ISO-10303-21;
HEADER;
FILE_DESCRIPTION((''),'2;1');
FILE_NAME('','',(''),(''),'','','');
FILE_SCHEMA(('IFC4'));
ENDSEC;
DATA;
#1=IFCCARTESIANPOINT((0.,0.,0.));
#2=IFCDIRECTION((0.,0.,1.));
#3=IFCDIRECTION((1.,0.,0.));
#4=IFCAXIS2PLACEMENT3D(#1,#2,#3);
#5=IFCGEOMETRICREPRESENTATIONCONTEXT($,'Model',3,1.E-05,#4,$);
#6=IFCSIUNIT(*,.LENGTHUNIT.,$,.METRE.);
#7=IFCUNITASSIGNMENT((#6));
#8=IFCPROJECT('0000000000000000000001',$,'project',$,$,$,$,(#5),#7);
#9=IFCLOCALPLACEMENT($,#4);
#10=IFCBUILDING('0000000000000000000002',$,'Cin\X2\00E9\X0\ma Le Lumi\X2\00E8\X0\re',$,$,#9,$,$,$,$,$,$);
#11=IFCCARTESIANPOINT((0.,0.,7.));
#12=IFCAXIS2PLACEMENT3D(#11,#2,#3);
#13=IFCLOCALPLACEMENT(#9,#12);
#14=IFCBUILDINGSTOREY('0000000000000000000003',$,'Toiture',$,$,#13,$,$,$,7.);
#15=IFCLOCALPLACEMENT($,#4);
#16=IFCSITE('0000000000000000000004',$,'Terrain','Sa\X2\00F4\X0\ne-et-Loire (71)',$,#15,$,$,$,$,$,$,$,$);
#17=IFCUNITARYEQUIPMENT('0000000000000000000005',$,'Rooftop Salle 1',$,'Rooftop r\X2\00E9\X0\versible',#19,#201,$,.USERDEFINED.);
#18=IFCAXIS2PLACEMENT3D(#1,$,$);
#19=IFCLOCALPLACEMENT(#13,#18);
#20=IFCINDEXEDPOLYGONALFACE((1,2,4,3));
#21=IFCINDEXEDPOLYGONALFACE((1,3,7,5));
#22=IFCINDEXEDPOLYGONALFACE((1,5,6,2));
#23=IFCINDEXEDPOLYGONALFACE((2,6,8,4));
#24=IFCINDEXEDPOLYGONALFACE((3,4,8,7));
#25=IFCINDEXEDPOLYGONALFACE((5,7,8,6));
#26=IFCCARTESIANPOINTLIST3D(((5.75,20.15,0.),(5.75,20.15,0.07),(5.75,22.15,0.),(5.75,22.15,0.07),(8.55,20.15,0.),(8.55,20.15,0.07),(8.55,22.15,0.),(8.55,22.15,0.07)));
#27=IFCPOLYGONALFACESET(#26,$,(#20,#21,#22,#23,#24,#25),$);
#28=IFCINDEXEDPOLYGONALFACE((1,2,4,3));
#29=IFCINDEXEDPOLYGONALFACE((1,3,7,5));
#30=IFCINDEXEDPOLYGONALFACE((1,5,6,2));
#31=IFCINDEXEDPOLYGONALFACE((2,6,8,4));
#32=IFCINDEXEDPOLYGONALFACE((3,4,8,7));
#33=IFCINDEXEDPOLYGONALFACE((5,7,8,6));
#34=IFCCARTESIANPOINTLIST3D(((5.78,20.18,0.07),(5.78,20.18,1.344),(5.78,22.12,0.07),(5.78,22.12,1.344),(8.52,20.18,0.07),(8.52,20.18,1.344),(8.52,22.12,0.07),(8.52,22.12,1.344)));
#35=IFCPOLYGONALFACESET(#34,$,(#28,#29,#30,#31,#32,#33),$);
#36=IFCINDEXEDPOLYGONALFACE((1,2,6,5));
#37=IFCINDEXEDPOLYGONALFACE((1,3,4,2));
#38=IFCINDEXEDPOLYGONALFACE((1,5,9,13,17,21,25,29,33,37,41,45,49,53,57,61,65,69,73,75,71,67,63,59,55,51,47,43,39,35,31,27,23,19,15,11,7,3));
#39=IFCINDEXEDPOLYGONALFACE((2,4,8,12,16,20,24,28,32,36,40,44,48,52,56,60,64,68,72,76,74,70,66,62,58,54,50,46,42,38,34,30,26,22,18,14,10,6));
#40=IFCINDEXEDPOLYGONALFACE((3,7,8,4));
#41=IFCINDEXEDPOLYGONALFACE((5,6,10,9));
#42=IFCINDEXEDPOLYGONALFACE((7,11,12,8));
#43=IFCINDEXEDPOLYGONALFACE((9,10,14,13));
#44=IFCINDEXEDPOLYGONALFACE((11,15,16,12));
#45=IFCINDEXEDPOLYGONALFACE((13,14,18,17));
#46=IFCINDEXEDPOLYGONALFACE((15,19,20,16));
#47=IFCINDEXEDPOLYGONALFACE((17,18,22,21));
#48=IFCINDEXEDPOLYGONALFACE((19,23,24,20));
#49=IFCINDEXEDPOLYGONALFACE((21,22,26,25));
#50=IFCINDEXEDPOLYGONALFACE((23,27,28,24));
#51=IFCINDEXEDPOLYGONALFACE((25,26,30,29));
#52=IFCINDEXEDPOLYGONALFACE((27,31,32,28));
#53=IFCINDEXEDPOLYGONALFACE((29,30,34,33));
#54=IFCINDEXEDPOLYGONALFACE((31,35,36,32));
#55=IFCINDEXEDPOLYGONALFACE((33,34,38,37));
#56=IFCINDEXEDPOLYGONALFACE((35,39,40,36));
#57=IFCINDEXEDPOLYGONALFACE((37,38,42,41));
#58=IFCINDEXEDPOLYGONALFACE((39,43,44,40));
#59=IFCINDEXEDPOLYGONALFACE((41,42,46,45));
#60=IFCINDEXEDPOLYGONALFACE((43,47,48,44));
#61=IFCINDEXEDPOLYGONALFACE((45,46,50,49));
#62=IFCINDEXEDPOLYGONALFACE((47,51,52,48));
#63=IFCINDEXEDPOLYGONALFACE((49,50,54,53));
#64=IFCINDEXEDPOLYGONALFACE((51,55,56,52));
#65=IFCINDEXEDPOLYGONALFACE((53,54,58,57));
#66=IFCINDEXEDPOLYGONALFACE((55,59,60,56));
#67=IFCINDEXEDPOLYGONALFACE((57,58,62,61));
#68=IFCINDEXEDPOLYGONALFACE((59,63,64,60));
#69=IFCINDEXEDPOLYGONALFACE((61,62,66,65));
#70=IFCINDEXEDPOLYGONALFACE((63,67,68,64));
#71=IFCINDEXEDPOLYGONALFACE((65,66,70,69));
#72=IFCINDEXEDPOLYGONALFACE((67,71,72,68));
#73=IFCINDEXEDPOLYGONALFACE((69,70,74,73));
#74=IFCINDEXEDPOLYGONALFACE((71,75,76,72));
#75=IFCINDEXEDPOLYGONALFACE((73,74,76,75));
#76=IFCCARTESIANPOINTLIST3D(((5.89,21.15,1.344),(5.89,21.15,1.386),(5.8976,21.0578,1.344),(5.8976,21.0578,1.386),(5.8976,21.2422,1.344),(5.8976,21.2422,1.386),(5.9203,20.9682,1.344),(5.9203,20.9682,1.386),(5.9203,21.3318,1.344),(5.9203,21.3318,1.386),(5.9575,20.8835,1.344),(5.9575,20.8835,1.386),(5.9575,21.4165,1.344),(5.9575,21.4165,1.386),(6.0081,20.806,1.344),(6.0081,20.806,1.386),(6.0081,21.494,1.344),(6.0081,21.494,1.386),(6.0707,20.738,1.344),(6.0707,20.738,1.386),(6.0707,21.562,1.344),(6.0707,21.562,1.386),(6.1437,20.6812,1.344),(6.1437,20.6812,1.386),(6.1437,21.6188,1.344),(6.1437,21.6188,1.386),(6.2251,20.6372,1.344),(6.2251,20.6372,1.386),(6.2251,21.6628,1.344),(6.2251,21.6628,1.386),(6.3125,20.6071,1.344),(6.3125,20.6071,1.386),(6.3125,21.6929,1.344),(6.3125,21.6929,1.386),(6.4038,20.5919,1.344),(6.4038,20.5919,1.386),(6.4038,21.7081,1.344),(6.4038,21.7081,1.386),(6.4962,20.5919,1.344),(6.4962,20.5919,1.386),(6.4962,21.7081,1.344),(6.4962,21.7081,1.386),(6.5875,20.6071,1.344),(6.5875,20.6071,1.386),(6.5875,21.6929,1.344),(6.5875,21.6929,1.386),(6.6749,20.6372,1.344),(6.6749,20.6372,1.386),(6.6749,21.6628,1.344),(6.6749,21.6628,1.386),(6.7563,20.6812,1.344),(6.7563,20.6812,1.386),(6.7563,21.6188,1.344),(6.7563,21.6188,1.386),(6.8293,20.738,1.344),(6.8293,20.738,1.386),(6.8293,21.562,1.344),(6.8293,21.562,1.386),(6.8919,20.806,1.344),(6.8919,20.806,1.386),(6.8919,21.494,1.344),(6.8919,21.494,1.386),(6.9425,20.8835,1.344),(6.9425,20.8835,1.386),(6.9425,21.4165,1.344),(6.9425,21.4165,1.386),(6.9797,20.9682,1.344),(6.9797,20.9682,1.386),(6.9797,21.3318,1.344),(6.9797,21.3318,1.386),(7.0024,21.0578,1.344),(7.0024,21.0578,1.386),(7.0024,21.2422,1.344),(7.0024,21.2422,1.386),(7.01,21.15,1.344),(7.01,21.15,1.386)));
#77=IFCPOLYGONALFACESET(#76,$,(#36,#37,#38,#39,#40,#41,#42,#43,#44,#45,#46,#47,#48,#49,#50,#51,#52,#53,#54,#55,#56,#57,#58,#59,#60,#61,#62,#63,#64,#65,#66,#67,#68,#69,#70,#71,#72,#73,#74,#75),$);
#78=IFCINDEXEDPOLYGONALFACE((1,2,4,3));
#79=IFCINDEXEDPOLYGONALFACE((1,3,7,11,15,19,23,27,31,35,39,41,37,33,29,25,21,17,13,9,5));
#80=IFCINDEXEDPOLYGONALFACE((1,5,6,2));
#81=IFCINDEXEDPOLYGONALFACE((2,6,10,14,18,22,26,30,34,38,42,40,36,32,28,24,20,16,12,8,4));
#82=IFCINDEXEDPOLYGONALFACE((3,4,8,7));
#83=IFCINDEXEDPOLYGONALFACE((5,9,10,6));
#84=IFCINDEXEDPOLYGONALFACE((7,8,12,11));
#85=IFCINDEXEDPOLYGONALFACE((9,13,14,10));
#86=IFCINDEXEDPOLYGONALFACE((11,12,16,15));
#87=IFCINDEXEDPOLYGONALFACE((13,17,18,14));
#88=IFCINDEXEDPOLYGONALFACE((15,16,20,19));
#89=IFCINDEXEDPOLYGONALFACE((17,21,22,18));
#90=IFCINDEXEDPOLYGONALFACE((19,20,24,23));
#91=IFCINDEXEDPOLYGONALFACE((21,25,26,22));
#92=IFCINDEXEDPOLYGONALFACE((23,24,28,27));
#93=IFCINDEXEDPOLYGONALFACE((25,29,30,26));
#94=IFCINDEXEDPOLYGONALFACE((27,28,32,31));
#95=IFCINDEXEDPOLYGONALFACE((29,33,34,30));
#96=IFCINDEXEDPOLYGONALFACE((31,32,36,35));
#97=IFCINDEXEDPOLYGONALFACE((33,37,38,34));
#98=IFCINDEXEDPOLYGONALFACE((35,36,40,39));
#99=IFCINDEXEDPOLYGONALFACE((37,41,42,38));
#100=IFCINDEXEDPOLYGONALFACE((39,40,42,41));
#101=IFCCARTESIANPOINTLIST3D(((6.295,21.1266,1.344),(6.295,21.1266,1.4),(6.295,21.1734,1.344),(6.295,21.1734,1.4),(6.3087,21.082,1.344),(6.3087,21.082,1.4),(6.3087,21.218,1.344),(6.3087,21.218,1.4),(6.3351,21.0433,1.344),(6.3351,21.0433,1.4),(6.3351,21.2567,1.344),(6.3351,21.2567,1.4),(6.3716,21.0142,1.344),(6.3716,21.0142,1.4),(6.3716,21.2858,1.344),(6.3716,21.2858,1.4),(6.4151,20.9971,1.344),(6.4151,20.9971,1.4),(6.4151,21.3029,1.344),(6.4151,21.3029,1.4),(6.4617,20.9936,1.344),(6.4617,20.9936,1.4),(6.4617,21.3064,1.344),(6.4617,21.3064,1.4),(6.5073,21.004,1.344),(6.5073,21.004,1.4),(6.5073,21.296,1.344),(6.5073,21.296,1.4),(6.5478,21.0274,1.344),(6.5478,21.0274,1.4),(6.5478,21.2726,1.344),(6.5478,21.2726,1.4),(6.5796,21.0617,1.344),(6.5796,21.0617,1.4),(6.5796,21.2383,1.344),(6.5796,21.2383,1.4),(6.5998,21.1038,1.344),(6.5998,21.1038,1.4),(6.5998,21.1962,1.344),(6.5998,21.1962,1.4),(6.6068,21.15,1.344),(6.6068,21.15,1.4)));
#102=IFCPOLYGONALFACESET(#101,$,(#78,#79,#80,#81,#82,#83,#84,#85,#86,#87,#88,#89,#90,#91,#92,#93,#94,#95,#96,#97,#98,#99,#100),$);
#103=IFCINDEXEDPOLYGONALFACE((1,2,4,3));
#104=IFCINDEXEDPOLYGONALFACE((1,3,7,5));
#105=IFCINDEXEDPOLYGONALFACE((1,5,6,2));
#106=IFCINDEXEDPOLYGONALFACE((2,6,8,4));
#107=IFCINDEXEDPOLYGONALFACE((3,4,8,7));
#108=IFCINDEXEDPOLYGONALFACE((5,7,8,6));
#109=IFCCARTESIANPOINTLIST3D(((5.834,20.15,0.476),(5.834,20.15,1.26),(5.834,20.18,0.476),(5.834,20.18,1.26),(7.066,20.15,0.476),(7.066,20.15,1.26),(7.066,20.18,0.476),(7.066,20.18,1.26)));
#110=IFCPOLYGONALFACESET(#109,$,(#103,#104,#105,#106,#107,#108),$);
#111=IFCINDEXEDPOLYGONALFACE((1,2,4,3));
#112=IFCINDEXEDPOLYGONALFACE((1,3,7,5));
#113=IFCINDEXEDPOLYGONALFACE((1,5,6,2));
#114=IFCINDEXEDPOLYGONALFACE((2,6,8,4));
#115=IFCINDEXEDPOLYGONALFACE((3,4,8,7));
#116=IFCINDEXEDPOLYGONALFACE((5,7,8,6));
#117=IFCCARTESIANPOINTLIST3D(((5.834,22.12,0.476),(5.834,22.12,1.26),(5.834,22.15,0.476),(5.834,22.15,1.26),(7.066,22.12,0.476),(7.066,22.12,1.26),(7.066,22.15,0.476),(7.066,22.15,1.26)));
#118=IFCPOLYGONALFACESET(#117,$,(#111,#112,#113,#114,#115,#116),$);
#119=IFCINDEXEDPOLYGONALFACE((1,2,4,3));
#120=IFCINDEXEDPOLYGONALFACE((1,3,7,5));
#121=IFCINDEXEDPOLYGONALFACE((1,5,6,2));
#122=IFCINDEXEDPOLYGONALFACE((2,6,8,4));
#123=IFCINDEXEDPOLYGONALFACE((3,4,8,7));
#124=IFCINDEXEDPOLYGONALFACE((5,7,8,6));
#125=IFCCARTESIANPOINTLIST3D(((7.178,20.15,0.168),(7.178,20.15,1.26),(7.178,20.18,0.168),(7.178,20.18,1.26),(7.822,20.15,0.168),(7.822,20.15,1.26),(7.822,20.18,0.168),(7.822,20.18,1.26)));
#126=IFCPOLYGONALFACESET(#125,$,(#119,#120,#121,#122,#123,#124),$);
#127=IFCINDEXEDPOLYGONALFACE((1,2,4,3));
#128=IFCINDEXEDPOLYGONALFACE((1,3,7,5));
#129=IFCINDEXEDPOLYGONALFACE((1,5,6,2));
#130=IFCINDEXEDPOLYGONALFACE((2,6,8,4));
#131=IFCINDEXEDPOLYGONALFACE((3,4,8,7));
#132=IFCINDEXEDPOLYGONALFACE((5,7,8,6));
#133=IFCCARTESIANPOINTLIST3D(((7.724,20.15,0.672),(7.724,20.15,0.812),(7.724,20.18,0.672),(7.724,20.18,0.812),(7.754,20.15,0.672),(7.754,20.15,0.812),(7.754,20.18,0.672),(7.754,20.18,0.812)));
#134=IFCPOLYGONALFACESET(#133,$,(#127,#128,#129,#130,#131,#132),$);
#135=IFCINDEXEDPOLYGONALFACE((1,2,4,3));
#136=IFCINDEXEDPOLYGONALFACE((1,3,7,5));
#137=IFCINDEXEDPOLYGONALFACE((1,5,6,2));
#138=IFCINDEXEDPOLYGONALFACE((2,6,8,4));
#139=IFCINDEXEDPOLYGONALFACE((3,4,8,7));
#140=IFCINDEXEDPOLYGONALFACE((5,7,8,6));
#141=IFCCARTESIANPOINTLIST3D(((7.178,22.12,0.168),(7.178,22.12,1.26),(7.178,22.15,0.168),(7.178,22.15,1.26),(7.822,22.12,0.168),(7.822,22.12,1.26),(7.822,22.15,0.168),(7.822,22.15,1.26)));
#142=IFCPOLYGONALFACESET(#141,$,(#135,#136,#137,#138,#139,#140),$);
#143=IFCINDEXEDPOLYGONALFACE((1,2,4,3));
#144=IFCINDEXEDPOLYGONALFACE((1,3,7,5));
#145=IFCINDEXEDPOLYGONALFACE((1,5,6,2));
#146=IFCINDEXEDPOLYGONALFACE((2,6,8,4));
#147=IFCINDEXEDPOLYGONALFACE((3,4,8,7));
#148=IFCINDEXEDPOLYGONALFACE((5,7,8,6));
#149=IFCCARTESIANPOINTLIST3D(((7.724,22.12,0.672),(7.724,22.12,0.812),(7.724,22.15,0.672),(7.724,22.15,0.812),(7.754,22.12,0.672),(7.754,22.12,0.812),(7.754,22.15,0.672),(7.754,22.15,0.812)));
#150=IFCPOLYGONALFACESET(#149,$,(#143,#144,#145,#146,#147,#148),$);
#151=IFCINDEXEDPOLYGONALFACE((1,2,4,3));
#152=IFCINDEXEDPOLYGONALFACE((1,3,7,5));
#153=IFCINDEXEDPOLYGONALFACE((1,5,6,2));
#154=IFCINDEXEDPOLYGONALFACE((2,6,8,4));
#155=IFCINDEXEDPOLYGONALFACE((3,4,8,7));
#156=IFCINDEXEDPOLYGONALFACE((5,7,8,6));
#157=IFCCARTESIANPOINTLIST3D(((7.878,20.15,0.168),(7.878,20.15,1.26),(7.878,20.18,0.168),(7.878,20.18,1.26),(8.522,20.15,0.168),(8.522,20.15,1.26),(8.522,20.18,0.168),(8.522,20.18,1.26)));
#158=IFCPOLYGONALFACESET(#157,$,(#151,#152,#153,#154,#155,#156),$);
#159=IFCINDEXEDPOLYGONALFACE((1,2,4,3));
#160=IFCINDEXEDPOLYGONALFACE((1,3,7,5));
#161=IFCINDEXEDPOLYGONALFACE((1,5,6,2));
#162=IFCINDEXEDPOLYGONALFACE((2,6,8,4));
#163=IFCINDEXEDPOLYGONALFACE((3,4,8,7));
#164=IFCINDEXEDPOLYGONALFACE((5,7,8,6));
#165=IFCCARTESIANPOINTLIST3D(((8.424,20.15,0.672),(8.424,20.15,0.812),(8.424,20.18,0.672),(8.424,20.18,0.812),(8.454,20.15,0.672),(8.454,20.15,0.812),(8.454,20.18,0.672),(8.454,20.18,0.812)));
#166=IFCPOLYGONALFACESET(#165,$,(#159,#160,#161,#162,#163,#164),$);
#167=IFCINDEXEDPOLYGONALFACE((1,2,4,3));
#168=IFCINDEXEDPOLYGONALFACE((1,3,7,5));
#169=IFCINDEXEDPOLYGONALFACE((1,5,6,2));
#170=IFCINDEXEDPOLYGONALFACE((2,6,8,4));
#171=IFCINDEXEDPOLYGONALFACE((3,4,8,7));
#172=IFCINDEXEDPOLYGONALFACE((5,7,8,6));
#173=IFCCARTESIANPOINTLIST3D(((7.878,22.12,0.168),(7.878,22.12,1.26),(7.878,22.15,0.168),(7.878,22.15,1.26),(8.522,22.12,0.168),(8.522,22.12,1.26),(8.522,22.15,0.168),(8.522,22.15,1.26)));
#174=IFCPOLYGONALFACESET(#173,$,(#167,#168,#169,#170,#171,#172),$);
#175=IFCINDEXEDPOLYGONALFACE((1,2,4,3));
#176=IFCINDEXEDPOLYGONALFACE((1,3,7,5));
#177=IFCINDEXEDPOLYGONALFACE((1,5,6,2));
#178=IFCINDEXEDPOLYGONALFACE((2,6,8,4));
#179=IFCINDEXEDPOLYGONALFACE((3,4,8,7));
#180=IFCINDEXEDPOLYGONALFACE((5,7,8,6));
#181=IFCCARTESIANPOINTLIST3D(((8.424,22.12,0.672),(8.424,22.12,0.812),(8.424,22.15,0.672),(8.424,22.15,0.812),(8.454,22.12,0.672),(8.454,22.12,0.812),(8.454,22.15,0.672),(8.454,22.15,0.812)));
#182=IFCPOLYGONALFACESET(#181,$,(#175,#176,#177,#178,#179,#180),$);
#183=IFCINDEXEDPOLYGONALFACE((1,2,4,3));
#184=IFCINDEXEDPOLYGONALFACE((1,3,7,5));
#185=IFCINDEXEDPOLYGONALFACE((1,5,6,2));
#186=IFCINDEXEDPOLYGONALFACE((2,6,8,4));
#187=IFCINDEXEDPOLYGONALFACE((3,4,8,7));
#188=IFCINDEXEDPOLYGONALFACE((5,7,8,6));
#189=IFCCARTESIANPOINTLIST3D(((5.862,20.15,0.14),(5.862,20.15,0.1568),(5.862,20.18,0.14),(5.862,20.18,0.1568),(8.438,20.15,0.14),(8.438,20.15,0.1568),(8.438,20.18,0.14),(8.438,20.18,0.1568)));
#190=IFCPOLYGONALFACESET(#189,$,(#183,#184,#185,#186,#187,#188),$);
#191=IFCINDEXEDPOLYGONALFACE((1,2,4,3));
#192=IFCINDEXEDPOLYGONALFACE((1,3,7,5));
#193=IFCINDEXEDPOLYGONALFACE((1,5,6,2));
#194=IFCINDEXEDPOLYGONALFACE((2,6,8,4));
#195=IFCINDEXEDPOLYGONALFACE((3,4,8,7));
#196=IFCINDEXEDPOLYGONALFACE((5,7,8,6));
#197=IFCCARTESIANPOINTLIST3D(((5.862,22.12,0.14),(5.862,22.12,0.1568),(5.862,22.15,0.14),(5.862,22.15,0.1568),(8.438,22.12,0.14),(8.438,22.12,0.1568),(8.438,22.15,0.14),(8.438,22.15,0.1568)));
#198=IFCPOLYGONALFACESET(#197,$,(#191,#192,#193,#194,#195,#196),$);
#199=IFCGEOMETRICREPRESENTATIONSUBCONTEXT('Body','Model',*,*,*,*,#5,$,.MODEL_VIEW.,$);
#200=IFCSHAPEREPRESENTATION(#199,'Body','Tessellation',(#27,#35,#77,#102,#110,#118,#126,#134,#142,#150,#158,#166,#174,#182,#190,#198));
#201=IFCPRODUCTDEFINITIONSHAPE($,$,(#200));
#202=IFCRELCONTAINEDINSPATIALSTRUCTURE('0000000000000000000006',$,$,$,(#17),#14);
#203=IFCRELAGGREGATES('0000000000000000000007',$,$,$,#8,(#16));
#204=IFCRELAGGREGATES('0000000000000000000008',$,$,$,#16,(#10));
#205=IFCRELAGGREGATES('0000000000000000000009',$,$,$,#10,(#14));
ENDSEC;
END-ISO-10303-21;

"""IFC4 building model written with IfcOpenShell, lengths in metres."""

from ifc_helpers import new_model, si_unit, frame, frame_2d, origin_with_axes, place, context, subcontext, project, spatial, rectangle, circle, extrude, element, save


model = new_model("IFC4")

# Units and contexts
model_context = context("Model", 3, precision=1e-05, world=origin_with_axes())
body_context = subcontext(model_context, "Body", "Model", "MODEL_VIEW")
ifc_project = project(units=[si_unit("LENGTHUNIT", "METRE")], contexts=[model_context])

# Site, building, storey
site_placement = place(None, origin_with_axes())
site = spatial("IfcSite", under=ifc_project, at=site_placement, Name="Terrain", Description="Saône-et-Loire (71)")
building_placement = place(None, origin_with_axes())
building = spatial("IfcBuilding", under=site, at=building_placement, Name="Cinéma Le Lumière")
storey_placement = place(building_placement, frame((0.0, 0.0, 7.0), z_axis=(0.0, 0.0, 1.0), x_axis=(1.0, 0.0, 0.0)))
storey = spatial("IfcBuildingStorey", under=building, at=storey_placement, Name="Toiture", Elevation=7.0)

# Unitary equipment
unitary_equipment_1_placement = place(storey_placement, frame((5.75, 20.15, 0.0), z_axis=(0.0, 0.0, 1.0), x_axis=(1.0, 0.0, 0.0)))
element("IfcUnitaryEquipment", 1, at=unitary_equipment_1_placement, inside=storey, Name="Rooftop Salle 1", ObjectType="Rooftop réversible", PredefinedType="USERDEFINED", context=body_context, shape_type="SweptSolid", body=[
    extrude(rectangle(XDim=2.8, YDim=2.0, at=frame_2d((1.4, 1.0))), origin_with_axes(), (0.0, 0.0, 1.0), 0.07),
    extrude(rectangle(XDim=2.74, YDim=1.94, at=frame_2d((1.37, 0.97))), frame((0.03, 0.03, 0.07), z_axis=(0.0, 0.0, 1.0), x_axis=(1.0, 0.0, 0.0)), (0.0, 0.0, 1.0), 1.274),
    extrude(circle(Radius=0.56), frame((0.7, 1.0, 1.344), z_axis=(0.0, 0.0, 1.0), x_axis=(1.0, 0.0, 0.0)), (0.0, 0.0, 1.0), 0.042),
    extrude(circle(Radius=0.1568), frame((0.7, 1.0, 1.344), z_axis=(0.0, 0.0, 1.0), x_axis=(1.0, 0.0, 0.0)), (0.0, 0.0, 1.0), 0.056),
    extrude(rectangle(XDim=1.232, YDim=0.03, at=frame_2d((0.616, 0.015))), frame((0.084, 0.0, 0.476), z_axis=(0.0, 0.0, 1.0), x_axis=(1.0, 0.0, 0.0)), (0.0, 0.0, 1.0), 0.784),
    extrude(rectangle(XDim=1.232, YDim=0.03, at=frame_2d((0.616, 0.015))), frame((0.084, 1.97, 0.476), z_axis=(0.0, 0.0, 1.0), x_axis=(1.0, 0.0, 0.0)), (0.0, 0.0, 1.0), 0.784),
    extrude(rectangle(XDim=0.644, YDim=0.03, at=frame_2d((0.322, 0.015))), frame((1.428, 0.0, 0.168), z_axis=(0.0, 0.0, 1.0), x_axis=(1.0, 0.0, 0.0)), (0.0, 0.0, 1.0), 1.092),
    extrude(rectangle(XDim=0.03, YDim=0.03, at=frame_2d((0.015, 0.015))), frame((1.974, 0.0, 0.672), z_axis=(0.0, 0.0, 1.0), x_axis=(1.0, 0.0, 0.0)), (0.0, 0.0, 1.0), 0.14),
    extrude(rectangle(XDim=0.644, YDim=0.03, at=frame_2d((0.322, 0.015))), frame((1.428, 1.97, 0.168), z_axis=(0.0, 0.0, 1.0), x_axis=(1.0, 0.0, 0.0)), (0.0, 0.0, 1.0), 1.092),
    extrude(rectangle(XDim=0.03, YDim=0.03, at=frame_2d((0.015, 0.015))), frame((1.974, 1.97, 0.672), z_axis=(0.0, 0.0, 1.0), x_axis=(1.0, 0.0, 0.0)), (0.0, 0.0, 1.0), 0.14),
    extrude(rectangle(XDim=0.644, YDim=0.03, at=frame_2d((0.322, 0.015))), frame((2.128, 0.0, 0.168), z_axis=(0.0, 0.0, 1.0), x_axis=(1.0, 0.0, 0.0)), (0.0, 0.0, 1.0), 1.092),
    extrude(rectangle(XDim=0.03, YDim=0.03, at=frame_2d((0.015, 0.015))), frame((2.674, 0.0, 0.672), z_axis=(0.0, 0.0, 1.0), x_axis=(1.0, 0.0, 0.0)), (0.0, 0.0, 1.0), 0.14),
    extrude(rectangle(XDim=0.644, YDim=0.03, at=frame_2d((0.322, 0.015))), frame((2.128, 1.97, 0.168), z_axis=(0.0, 0.0, 1.0), x_axis=(1.0, 0.0, 0.0)), (0.0, 0.0, 1.0), 1.092),
    extrude(rectangle(XDim=0.03, YDim=0.03, at=frame_2d((0.015, 0.015))), frame((2.674, 1.97, 0.672), z_axis=(0.0, 0.0, 1.0), x_axis=(1.0, 0.0, 0.0)), (0.0, 0.0, 1.0), 0.14),
    extrude(rectangle(XDim=2.576, YDim=0.03, at=frame_2d((1.288, 0.015))), frame((0.112, 0.0, 0.14), z_axis=(0.0, 0.0, 1.0), x_axis=(1.0, 0.0, 0.0)), (0.0, 0.0, 1.0), 0.0168),
    extrude(rectangle(XDim=2.576, YDim=0.03, at=frame_2d((1.288, 0.015))), frame((0.112, 1.97, 0.14), z_axis=(0.0, 0.0, 1.0), x_axis=(1.0, 0.0, 0.0)), (0.0, 0.0, 1.0), 0.0168),
])

save(model, "model.ifc")
